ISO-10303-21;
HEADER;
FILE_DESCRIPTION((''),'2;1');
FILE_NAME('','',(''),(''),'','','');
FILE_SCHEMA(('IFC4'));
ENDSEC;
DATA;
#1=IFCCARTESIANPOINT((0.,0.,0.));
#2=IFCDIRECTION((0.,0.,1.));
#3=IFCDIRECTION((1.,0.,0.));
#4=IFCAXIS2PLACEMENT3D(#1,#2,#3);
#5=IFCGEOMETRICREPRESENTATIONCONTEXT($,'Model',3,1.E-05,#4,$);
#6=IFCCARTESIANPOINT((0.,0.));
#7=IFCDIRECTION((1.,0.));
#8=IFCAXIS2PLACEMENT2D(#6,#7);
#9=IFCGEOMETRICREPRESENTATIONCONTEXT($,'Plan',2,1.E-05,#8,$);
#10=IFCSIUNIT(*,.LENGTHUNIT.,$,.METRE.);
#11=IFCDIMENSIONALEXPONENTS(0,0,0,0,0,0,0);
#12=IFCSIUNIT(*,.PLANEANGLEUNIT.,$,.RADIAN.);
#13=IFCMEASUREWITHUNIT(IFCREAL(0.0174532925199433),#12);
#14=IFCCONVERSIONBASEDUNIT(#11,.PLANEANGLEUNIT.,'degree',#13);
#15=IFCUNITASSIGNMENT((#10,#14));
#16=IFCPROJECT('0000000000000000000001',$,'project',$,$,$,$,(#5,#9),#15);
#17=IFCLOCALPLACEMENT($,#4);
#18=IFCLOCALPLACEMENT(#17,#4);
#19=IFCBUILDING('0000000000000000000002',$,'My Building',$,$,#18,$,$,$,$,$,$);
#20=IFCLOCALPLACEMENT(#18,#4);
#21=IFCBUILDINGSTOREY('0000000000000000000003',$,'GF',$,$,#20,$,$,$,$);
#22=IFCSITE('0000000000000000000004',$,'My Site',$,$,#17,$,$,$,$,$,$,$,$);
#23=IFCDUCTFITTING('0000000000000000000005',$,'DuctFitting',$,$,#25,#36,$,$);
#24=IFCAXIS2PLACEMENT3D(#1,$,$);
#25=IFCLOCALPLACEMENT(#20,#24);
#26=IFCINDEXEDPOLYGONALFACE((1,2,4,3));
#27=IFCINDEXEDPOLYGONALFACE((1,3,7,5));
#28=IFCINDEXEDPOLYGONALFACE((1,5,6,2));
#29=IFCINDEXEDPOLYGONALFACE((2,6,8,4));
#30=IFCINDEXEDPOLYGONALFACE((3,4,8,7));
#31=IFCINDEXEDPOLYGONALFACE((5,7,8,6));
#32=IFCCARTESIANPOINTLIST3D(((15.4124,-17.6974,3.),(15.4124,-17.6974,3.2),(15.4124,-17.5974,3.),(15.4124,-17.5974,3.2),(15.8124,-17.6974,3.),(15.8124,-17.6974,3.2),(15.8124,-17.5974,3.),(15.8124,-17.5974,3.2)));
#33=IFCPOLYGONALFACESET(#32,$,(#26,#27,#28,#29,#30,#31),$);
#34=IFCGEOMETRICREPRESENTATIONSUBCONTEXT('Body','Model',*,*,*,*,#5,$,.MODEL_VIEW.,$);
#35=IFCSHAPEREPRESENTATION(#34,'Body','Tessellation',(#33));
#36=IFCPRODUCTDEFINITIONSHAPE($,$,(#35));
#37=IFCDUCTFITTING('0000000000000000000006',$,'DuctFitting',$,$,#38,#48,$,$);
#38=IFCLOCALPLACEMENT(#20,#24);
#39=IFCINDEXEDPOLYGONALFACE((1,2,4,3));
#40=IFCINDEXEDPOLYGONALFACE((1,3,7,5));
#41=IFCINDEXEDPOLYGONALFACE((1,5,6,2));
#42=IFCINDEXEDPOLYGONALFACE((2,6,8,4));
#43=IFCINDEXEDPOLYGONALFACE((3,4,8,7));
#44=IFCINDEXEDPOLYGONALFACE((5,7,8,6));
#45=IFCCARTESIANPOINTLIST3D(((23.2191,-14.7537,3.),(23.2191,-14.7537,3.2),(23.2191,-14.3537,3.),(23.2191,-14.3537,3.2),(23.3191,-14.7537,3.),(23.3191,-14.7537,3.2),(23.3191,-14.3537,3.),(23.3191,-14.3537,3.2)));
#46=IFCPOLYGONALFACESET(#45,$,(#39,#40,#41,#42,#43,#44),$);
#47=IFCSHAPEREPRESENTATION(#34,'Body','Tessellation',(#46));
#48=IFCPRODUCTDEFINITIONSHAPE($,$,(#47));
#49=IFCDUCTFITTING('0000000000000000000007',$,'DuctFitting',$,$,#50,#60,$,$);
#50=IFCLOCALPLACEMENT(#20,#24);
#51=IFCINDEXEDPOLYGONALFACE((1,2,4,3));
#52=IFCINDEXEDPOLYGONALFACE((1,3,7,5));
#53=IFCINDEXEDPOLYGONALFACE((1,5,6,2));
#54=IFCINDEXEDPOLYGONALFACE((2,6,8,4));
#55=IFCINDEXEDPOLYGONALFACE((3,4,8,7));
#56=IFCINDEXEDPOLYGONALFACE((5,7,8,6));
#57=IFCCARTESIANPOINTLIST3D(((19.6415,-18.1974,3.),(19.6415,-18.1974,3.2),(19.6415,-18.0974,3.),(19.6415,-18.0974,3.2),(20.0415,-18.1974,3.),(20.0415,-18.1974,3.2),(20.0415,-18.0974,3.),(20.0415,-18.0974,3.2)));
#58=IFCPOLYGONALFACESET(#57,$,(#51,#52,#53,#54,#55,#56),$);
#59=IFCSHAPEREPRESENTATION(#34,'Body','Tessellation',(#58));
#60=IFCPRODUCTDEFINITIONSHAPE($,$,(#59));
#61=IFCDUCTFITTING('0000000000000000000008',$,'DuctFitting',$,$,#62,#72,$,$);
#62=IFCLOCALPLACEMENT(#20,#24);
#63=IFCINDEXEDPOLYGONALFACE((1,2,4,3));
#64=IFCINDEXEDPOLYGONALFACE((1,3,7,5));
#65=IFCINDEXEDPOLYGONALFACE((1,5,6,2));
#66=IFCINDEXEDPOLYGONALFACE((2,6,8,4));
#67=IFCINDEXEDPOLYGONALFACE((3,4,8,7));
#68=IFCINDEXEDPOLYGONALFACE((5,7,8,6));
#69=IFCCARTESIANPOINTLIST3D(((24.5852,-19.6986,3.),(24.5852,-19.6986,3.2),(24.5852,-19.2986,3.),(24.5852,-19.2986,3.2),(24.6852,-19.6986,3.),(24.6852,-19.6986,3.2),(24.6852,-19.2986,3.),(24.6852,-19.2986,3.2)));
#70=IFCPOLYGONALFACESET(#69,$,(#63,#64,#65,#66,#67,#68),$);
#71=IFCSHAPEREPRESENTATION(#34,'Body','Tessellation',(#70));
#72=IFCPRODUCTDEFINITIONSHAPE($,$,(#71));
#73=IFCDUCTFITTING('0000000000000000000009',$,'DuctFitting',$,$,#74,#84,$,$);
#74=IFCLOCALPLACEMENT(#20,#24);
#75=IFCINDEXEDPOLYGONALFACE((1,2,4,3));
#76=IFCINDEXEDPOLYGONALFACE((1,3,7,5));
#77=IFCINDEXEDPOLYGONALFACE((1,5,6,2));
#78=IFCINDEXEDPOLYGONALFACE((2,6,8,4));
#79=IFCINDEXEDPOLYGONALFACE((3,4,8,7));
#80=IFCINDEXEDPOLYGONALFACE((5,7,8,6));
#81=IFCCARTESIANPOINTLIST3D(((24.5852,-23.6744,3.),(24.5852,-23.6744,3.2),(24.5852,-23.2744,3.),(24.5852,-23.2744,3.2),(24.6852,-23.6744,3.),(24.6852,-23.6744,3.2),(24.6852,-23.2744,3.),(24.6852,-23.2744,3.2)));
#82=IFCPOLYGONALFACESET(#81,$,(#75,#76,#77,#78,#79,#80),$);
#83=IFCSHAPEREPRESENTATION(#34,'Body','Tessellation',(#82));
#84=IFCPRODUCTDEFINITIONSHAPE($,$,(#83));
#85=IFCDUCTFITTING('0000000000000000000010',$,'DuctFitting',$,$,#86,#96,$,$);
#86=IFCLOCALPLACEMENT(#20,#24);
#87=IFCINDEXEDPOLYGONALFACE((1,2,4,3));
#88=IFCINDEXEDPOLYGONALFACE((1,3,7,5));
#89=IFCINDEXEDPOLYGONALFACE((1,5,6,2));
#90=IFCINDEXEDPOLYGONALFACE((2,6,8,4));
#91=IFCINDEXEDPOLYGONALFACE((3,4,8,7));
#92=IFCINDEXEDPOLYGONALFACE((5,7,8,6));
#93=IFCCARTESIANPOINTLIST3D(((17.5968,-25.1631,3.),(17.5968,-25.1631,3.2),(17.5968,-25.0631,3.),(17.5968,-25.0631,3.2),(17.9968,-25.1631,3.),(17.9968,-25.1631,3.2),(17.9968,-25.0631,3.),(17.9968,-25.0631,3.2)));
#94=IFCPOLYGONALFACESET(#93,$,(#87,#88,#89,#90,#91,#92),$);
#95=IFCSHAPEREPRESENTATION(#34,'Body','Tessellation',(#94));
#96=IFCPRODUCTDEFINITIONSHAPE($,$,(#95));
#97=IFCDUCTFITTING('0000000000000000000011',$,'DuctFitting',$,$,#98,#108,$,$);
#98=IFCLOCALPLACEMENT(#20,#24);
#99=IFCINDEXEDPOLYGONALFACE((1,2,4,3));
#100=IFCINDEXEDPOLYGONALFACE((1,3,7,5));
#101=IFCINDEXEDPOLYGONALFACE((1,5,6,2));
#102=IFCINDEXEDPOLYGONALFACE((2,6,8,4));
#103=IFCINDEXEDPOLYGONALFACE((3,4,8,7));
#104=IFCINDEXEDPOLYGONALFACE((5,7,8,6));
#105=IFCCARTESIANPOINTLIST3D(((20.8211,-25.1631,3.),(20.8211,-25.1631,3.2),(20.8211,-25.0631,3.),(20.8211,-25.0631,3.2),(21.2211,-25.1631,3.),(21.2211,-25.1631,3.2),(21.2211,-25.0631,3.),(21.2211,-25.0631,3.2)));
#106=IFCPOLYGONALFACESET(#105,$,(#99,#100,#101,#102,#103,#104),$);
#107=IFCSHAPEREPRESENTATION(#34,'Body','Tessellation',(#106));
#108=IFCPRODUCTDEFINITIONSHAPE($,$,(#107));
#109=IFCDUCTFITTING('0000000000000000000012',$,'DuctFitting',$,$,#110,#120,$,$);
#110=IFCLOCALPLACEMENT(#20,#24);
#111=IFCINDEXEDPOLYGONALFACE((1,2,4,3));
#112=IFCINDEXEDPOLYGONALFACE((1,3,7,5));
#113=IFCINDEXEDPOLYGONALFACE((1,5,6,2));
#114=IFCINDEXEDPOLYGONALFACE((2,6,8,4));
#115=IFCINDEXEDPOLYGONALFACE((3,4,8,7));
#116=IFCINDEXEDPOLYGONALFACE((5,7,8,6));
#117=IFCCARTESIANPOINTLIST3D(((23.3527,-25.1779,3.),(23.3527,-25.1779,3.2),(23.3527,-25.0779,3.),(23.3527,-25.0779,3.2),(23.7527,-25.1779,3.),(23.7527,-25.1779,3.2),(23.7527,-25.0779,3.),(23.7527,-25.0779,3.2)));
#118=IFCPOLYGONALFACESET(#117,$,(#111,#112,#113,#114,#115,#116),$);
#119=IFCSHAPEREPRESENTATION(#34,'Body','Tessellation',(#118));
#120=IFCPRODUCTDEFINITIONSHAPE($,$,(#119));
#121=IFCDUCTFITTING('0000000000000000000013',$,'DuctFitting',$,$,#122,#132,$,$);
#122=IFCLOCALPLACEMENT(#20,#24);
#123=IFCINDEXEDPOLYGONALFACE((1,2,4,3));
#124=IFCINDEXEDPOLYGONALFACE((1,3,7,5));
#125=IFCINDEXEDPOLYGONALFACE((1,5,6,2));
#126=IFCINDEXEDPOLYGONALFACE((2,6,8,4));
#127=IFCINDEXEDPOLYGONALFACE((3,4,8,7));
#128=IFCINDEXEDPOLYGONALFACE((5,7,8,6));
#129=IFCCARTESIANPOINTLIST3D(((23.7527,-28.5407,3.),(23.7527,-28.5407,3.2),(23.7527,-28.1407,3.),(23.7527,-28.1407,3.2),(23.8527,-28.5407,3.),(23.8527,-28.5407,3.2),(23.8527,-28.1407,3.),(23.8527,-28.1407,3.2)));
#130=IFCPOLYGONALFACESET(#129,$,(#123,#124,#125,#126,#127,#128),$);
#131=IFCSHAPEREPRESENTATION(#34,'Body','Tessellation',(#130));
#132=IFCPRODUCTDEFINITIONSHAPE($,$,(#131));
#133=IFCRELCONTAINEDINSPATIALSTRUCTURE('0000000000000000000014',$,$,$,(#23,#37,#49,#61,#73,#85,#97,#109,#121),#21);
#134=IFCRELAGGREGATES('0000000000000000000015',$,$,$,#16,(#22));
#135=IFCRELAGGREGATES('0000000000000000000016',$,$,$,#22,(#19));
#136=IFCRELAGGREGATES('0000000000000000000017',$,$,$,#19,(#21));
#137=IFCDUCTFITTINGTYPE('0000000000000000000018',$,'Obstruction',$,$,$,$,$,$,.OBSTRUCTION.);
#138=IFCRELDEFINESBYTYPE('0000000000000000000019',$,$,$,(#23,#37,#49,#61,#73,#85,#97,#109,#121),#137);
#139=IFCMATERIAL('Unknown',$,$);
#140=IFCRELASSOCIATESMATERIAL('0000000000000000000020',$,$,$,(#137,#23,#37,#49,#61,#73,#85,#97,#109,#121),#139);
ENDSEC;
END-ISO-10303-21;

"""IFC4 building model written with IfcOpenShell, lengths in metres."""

from ifc_helpers import new_model, entity, si_unit, converted_unit, frame, origin_with_axes, origin_2d_with_axis, place, context, subcontext, project, spatial, rectangle, extrude, material, material_profile, profile_set, profile_usage, type_object, element, save


model = new_model("IFC4")

# Units and contexts
model_context = context("Model", 3, precision=1e-05, world=origin_with_axes())
plan_context = context("Plan", 2, precision=1e-05, world=origin_2d_with_axis())
body_context_1 = subcontext(model_context, "Body", "Model", "MODEL_VIEW")
ifc_project = project(units=[si_unit("LENGTHUNIT", "METRE"), converted_unit("PLANEANGLEUNIT", "degree", entity("IfcReal", 0.0174532925199433), si_unit("PLANEANGLEUNIT", "RADIAN"), dimensions=[0, 0, 0, 0, 0, 0, 0])], contexts=[model_context, plan_context])

# Site, building, storey
site_placement = place(None, origin_with_axes())
site = spatial("IfcSite", under=ifc_project, at=site_placement, Name="My Site")
building_placement = place(site_placement, origin_with_axes())
building = spatial("IfcBuilding", under=site, at=building_placement, Name="My Building")
storey_placement = place(building_placement, origin_with_axes())
storey = spatial("IfcBuildingStorey", under=building, at=storey_placement, Name="GF")

# Shared definitions
ifc_material = material(Name="Unknown")

# Duct fittings
ifc_material_profile = material_profile(ifc_material, rectangle(XDim=0.4, YDim=0.2))
ifc_profile_set = profile_set([ifc_material_profile])
duct_fitting_type = type_object("IfcDuctFittingType", Name="Obstruction", PredefinedType="OBSTRUCTION", material=ifc_profile_set)
ifc_profile_usage_1 = profile_usage(ifc_profile_set, cardinal=5)
duct_fitting_1_placement = place(storey_placement, frame((15.6124, -17.6974, 3.1), z_axis=(0.0, 1.0, -0.000003), x_axis=(-1.0, 0.0, 0.0)))
element("IfcDuctFitting", 1, at=duct_fitting_1_placement, inside=storey, type_object=duct_fitting_type, material=ifc_profile_usage_1, Name="DuctFitting", context=body_context_1, shape_type="SweptSolid", body=[
    extrude(rectangle(XDim=0.4, YDim=0.2), origin_with_axes(), (0.0, 0.0, 1.0), 0.1),
])
ifc_profile_usage_2 = profile_usage(ifc_profile_set, cardinal=5)
duct_fitting_2_placement = place(storey_placement, frame((23.3191, -14.5537, 3.1), z_axis=(-1.0, 0.0, -0.000003), x_axis=(0.0, -1.0, 0.0)))
element("IfcDuctFitting", 2, at=duct_fitting_2_placement, inside=storey, type_object=duct_fitting_type, material=ifc_profile_usage_2, Name="DuctFitting", context=body_context_1, shape_type="SweptSolid", body=[
    extrude(rectangle(XDim=0.4, YDim=0.2), origin_with_axes(), (0.0, 0.0, 1.0), 0.1),
])
ifc_profile_usage_3 = profile_usage(ifc_profile_set, cardinal=5)
duct_fitting_3_placement = place(storey_placement, frame((19.8415, -18.1974, 3.1), z_axis=(0.0, 1.0, -0.000003), x_axis=(-1.0, 0.0, 0.0)))
element("IfcDuctFitting", 3, at=duct_fitting_3_placement, inside=storey, type_object=duct_fitting_type, material=ifc_profile_usage_3, Name="DuctFitting", context=body_context_1, shape_type="SweptSolid", body=[
    extrude(rectangle(XDim=0.4, YDim=0.2), origin_with_axes(), (0.0, 0.0, 1.0), 0.1),
])
ifc_profile_usage_4 = profile_usage(ifc_profile_set, cardinal=5)
duct_fitting_4_placement = place(storey_placement, frame((24.6852, -19.4986, 3.1), z_axis=(-1.0, 0.0, -0.000003), x_axis=(0.0, -1.0, 0.0)))
element("IfcDuctFitting", 4, at=duct_fitting_4_placement, inside=storey, type_object=duct_fitting_type, material=ifc_profile_usage_4, Name="DuctFitting", context=body_context_1, shape_type="SweptSolid", body=[
    extrude(rectangle(XDim=0.4, YDim=0.2), origin_with_axes(), (0.0, 0.0, 1.0), 0.1),
])
ifc_profile_usage_5 = profile_usage(ifc_profile_set, cardinal=5)
duct_fitting_5_placement = place(storey_placement, frame((24.6852, -23.4744, 3.1), z_axis=(-1.0, 0.0, -0.000003), x_axis=(0.0, -1.0, 0.0)))
element("IfcDuctFitting", 5, at=duct_fitting_5_placement, inside=storey, type_object=duct_fitting_type, material=ifc_profile_usage_5, Name="DuctFitting", context=body_context_1, shape_type="SweptSolid", body=[
    extrude(rectangle(XDim=0.4, YDim=0.2), origin_with_axes(), (0.0, 0.0, 1.0), 0.1),
])
ifc_profile_usage_6 = profile_usage(ifc_profile_set, cardinal=5)
duct_fitting_6_placement = place(storey_placement, frame((17.7968, -25.1631, 3.1), z_axis=(0.0, 1.0, -0.000003), x_axis=(-1.0, 0.0, 0.0)))
element("IfcDuctFitting", 6, at=duct_fitting_6_placement, inside=storey, type_object=duct_fitting_type, material=ifc_profile_usage_6, Name="DuctFitting", context=body_context_1, shape_type="SweptSolid", body=[
    extrude(rectangle(XDim=0.4, YDim=0.2), origin_with_axes(), (0.0, 0.0, 1.0), 0.1),
])
ifc_profile_usage_7 = profile_usage(ifc_profile_set, cardinal=5)
duct_fitting_7_placement = place(storey_placement, frame((21.0211, -25.1631, 3.1), z_axis=(0.0, 1.0, -0.000003), x_axis=(-1.0, 0.0, 0.0)))
element("IfcDuctFitting", 7, at=duct_fitting_7_placement, inside=storey, type_object=duct_fitting_type, material=ifc_profile_usage_7, Name="DuctFitting", context=body_context_1, shape_type="SweptSolid", body=[
    extrude(rectangle(XDim=0.4, YDim=0.2), origin_with_axes(), (0.0, 0.0, 1.0), 0.1),
])
ifc_profile_usage_8 = profile_usage(ifc_profile_set, cardinal=5)
duct_fitting_8_placement = place(storey_placement, frame((23.5527, -25.1779, 3.1), z_axis=(0.0, 1.0, -0.000003), x_axis=(-1.0, 0.0, 0.0)))
element("IfcDuctFitting", 8, at=duct_fitting_8_placement, inside=storey, type_object=duct_fitting_type, material=ifc_profile_usage_8, Name="DuctFitting", context=body_context_1, shape_type="SweptSolid", body=[
    extrude(rectangle(XDim=0.4, YDim=0.2), origin_with_axes(), (0.0, 0.0, 1.0), 0.1),
])
ifc_profile_usage_9 = profile_usage(ifc_profile_set, cardinal=5)
duct_fitting_9_placement = place(storey_placement, frame((23.8527, -28.3407, 3.1), z_axis=(-1.0, 0.0, -0.000003), x_axis=(0.0, -1.0, 0.0)))
element("IfcDuctFitting", 9, at=duct_fitting_9_placement, inside=storey, type_object=duct_fitting_type, material=ifc_profile_usage_9, Name="DuctFitting", context=body_context_1, shape_type="SweptSolid", body=[
    extrude(rectangle(XDim=0.4, YDim=0.2), origin_with_axes(), (0.0, 0.0, 1.0), 0.1),
])

save(model, "model.ifc")
